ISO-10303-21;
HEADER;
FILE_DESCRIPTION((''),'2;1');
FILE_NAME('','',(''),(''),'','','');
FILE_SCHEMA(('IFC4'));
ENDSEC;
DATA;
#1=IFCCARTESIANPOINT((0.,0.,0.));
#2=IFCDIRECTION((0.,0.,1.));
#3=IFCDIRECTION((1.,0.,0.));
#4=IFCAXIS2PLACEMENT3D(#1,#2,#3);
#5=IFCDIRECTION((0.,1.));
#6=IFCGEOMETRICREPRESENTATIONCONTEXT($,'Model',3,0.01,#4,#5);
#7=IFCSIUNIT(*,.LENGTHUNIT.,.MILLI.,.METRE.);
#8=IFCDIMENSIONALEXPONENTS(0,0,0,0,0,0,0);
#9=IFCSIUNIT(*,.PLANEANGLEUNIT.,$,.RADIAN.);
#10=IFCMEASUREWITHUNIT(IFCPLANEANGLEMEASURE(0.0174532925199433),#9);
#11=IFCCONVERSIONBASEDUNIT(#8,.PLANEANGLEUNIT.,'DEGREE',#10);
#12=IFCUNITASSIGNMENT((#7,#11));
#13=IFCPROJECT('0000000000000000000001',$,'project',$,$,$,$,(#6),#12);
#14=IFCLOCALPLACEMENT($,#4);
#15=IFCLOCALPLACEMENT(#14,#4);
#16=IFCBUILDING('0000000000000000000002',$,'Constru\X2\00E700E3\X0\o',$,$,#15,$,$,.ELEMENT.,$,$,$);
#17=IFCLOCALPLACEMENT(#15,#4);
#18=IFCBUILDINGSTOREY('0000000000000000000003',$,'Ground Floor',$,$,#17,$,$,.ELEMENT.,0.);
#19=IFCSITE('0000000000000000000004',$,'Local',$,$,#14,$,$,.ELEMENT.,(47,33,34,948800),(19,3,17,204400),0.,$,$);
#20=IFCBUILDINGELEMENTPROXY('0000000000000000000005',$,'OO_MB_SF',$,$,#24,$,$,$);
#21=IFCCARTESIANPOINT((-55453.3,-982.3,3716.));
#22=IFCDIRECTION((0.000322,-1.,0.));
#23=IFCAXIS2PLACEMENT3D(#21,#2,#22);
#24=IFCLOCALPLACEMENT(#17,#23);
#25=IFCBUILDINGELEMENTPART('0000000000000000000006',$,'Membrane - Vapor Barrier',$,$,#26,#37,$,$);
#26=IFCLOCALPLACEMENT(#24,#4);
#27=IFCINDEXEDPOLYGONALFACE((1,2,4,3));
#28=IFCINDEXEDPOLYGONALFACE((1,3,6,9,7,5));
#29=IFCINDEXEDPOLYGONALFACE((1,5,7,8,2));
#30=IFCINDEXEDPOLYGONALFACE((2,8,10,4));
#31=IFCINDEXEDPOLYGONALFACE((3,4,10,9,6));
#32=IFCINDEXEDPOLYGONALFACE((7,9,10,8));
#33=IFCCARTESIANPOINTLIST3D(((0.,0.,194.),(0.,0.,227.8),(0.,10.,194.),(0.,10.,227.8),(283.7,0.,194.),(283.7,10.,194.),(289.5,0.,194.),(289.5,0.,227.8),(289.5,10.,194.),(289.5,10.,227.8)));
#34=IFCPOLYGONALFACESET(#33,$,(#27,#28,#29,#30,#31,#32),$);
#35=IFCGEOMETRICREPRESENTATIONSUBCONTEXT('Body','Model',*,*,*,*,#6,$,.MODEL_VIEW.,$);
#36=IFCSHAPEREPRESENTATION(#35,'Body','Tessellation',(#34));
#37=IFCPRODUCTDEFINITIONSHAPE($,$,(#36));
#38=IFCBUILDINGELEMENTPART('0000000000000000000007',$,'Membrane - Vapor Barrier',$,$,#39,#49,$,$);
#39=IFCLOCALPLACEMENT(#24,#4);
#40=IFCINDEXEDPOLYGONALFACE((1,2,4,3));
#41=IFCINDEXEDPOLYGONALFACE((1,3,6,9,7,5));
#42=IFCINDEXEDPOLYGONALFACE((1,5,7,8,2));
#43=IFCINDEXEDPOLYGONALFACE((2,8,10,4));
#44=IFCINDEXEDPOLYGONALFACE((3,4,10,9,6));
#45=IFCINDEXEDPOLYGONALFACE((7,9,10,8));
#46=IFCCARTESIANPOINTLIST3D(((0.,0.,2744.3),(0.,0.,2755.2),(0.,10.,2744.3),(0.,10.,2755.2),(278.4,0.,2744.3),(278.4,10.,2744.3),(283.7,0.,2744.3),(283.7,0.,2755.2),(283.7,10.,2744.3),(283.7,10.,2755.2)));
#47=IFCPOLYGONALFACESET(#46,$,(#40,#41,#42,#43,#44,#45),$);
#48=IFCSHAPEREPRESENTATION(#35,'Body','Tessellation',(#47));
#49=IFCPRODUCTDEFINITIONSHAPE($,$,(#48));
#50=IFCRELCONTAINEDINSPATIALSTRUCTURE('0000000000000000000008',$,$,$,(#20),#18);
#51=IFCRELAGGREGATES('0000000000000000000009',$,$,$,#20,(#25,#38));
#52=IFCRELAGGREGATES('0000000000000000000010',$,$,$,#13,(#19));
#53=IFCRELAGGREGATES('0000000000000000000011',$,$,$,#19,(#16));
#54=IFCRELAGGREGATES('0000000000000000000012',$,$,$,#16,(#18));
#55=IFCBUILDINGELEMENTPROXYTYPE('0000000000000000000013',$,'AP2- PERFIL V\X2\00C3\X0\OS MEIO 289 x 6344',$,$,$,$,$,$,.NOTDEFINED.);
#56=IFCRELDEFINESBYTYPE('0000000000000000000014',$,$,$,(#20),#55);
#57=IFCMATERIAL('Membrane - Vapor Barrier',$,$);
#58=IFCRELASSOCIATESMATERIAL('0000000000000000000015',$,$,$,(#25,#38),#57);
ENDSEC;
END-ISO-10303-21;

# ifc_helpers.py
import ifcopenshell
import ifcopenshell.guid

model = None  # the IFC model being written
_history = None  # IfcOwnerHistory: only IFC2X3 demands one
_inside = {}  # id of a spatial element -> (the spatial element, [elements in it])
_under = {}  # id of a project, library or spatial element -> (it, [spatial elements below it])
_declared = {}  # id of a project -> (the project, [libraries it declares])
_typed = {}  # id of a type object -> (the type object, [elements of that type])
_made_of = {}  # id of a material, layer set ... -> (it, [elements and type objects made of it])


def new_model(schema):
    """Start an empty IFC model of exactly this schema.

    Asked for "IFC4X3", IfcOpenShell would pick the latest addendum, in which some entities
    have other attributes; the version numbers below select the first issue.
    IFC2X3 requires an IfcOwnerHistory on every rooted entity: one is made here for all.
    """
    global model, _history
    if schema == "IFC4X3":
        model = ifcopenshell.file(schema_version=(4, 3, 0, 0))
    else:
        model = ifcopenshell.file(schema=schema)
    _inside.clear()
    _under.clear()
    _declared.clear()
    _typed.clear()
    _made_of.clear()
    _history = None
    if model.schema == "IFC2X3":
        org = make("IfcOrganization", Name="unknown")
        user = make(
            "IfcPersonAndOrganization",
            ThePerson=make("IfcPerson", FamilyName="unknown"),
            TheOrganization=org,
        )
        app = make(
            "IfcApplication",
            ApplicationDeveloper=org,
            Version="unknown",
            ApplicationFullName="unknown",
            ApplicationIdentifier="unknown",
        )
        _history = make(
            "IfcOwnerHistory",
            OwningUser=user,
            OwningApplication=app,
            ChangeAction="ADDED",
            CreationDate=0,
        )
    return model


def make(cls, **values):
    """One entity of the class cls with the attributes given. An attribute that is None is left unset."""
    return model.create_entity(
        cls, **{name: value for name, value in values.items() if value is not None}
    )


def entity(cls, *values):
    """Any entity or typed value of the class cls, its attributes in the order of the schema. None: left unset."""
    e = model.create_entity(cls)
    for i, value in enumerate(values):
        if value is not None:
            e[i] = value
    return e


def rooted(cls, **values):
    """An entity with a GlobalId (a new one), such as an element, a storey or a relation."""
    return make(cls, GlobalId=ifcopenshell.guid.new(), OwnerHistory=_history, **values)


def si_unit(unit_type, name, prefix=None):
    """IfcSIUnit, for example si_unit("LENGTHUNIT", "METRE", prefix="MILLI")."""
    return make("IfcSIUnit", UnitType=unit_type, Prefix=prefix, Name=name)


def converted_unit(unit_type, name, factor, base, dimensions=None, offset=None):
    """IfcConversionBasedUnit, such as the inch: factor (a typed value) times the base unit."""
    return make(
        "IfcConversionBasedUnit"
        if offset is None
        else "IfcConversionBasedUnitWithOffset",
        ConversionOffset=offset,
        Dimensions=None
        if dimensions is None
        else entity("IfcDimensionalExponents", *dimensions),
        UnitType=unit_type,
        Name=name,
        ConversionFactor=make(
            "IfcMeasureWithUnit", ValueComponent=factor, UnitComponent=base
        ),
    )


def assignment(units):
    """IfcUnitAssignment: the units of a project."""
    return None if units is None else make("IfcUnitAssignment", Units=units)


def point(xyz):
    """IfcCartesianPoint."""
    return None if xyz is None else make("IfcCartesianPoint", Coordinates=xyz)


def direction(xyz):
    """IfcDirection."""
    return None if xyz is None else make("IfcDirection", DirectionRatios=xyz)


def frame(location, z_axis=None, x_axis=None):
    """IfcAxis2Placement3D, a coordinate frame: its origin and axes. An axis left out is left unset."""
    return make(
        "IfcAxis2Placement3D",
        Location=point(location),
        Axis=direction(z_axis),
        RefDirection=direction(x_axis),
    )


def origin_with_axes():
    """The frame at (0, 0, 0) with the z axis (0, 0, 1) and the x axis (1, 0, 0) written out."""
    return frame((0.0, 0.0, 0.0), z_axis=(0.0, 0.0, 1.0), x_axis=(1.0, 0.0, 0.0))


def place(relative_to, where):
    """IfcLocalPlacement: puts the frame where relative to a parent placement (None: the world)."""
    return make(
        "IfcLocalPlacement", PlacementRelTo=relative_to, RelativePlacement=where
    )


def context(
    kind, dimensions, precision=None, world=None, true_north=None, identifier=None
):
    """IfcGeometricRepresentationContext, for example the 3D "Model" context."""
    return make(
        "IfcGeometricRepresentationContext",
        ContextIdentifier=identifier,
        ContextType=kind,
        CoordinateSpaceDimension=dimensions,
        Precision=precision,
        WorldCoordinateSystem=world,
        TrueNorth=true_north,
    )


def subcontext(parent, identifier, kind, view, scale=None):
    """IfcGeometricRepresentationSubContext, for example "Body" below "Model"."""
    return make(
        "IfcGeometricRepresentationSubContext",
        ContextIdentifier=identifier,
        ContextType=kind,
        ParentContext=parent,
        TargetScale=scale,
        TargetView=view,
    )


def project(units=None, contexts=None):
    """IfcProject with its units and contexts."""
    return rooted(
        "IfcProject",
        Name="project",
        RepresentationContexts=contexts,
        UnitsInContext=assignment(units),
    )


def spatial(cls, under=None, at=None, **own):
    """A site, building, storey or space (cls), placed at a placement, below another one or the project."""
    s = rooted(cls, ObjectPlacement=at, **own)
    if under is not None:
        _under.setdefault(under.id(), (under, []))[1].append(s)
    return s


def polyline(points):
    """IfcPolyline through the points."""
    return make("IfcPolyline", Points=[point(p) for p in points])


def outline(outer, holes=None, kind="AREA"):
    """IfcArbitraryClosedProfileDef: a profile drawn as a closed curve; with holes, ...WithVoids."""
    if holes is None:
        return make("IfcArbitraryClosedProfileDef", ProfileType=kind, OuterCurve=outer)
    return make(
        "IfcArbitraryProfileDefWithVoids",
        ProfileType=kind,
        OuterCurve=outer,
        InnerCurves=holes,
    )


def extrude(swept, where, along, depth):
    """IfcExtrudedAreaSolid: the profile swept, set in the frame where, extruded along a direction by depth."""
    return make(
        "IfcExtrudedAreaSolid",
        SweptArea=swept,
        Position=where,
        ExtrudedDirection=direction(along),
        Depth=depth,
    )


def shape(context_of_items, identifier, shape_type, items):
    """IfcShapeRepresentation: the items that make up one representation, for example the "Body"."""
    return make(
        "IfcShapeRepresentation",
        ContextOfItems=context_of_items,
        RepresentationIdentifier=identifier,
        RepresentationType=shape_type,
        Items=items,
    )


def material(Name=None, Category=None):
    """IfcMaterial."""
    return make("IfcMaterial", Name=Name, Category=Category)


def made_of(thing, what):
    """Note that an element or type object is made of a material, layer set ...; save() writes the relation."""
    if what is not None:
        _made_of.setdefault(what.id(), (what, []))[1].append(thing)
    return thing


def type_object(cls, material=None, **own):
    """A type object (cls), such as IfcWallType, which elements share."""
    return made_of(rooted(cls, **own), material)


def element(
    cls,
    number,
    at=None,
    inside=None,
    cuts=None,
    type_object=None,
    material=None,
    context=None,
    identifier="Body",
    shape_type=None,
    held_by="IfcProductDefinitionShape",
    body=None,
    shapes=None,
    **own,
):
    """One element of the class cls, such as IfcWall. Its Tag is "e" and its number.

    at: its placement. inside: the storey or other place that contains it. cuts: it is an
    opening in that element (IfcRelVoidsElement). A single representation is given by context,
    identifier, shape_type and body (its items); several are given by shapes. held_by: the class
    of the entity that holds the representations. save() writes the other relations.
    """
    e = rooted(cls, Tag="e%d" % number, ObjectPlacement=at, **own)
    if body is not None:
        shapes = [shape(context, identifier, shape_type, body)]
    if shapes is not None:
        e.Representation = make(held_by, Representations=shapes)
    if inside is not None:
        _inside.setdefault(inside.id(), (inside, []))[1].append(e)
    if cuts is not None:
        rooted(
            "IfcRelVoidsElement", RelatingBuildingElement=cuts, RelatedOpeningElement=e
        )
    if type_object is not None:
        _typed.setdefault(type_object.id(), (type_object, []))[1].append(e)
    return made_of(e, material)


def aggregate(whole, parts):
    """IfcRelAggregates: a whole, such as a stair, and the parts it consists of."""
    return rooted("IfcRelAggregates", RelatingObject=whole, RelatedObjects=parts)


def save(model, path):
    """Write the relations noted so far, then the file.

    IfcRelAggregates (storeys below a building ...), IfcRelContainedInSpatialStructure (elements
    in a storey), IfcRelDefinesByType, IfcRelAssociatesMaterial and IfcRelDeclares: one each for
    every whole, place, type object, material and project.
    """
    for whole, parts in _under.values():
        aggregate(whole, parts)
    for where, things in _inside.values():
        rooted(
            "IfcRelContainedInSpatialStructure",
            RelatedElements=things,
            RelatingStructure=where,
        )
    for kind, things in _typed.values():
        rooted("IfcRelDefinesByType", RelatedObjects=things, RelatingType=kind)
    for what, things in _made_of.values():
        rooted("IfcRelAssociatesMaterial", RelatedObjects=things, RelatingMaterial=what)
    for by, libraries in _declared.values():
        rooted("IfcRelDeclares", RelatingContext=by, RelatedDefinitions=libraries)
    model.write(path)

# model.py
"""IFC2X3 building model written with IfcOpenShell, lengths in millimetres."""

from ifc_helpers import new_model, entity, si_unit, converted_unit, direction, frame, origin_with_axes, place, context, subcontext, project, spatial, polyline, outline, extrude, material, type_object, element, aggregate, save


model = new_model("IFC2X3")

# Units and contexts
model_context = context("Model", 3, precision=0.01, world=origin_with_axes(), true_north=direction((0.0, 1.0)))
body_context = subcontext(model_context, "Body", "Model", "MODEL_VIEW")
ifc_project = project(units=[si_unit("LENGTHUNIT", "METRE", prefix="MILLI"), converted_unit("PLANEANGLEUNIT", "DEGREE", entity("IfcPlaneAngleMeasure", 0.0174532925199433), si_unit("PLANEANGLEUNIT", "RADIAN"), dimensions=[0, 0, 0, 0, 0, 0, 0])], contexts=[model_context])

# Site, building, storey
site_placement = place(None, origin_with_axes())
site = spatial("IfcSite", under=ifc_project, at=site_placement, Name="Local", CompositionType="ELEMENT", RefLatitude=(47, 33, 34, 948800), RefLongitude=(19, 3, 17, 204400), RefElevation=0.0)
building_placement = place(site_placement, origin_with_axes())
building = spatial("IfcBuilding", under=site, at=building_placement, Name="Construção", CompositionType="ELEMENT")
storey_placement = place(building_placement, origin_with_axes())
storey = spatial("IfcBuildingStorey", under=building, at=storey_placement, Name="Ground Floor", CompositionType="ELEMENT", Elevation=0.0)

# Building element proxy, building element parts
building_element_proxy_type = type_object("IfcBuildingElementProxyType", Name="AP2- PERFIL VÃOS MEIO 289 x 6344", PredefinedType="NOTDEFINED")
ifc_material_1 = material(Name="Membrane - Vapor Barrier")
proxy_1_placement = place(storey_placement, frame((-55453.3, -982.3, 3716.0), z_axis=(0.0, 0.0, 1.0), x_axis=(0.000322, -1.0, 0.0)))
proxy_1 = element("IfcBuildingElementProxy", 1, at=proxy_1_placement, inside=storey, type_object=building_element_proxy_type, Name="OO_MB_SF")
building_element_part_1_placement = place(proxy_1_placement, origin_with_axes())
building_element_part_1 = element("IfcBuildingElementPart", 2, at=building_element_part_1_placement, material=ifc_material_1, Name="Membrane - Vapor Barrier", context=body_context, shape_type="SweptSolid", body=[
    extrude(outline(polyline([(0.0, 194.0), (283.7, 194.0), (289.5, 194.0), (289.5, 227.8), (0.0, 227.8), (0.0, 194.0)])), frame((0.0, 10.0, 0.0), z_axis=(0.0, -1.0, 0.0), x_axis=(1.0, 0.0, 0.0)), (0.0, 0.0, 1.0), 10.0),
])
building_element_part_2_placement = place(proxy_1_placement, origin_with_axes())
building_element_part_2 = element("IfcBuildingElementPart", 3, at=building_element_part_2_placement, material=ifc_material_1, Name="Membrane - Vapor Barrier", context=body_context, shape_type="SweptSolid", body=[
    extrude(outline(polyline([(0.0, 2744.3), (278.4, 2744.3), (283.7, 2744.3), (283.7, 2755.2), (0.0, 2755.2), (0.0, 2744.3)])), frame((0.0, 10.0, 0.0), z_axis=(0.0, -1.0, 0.0), x_axis=(1.0, 0.0, 0.0)), (0.0, 0.0, 1.0), 10.0),
])
aggregate(proxy_1, [building_element_part_1, building_element_part_2])

save(model, "model.ifc")
